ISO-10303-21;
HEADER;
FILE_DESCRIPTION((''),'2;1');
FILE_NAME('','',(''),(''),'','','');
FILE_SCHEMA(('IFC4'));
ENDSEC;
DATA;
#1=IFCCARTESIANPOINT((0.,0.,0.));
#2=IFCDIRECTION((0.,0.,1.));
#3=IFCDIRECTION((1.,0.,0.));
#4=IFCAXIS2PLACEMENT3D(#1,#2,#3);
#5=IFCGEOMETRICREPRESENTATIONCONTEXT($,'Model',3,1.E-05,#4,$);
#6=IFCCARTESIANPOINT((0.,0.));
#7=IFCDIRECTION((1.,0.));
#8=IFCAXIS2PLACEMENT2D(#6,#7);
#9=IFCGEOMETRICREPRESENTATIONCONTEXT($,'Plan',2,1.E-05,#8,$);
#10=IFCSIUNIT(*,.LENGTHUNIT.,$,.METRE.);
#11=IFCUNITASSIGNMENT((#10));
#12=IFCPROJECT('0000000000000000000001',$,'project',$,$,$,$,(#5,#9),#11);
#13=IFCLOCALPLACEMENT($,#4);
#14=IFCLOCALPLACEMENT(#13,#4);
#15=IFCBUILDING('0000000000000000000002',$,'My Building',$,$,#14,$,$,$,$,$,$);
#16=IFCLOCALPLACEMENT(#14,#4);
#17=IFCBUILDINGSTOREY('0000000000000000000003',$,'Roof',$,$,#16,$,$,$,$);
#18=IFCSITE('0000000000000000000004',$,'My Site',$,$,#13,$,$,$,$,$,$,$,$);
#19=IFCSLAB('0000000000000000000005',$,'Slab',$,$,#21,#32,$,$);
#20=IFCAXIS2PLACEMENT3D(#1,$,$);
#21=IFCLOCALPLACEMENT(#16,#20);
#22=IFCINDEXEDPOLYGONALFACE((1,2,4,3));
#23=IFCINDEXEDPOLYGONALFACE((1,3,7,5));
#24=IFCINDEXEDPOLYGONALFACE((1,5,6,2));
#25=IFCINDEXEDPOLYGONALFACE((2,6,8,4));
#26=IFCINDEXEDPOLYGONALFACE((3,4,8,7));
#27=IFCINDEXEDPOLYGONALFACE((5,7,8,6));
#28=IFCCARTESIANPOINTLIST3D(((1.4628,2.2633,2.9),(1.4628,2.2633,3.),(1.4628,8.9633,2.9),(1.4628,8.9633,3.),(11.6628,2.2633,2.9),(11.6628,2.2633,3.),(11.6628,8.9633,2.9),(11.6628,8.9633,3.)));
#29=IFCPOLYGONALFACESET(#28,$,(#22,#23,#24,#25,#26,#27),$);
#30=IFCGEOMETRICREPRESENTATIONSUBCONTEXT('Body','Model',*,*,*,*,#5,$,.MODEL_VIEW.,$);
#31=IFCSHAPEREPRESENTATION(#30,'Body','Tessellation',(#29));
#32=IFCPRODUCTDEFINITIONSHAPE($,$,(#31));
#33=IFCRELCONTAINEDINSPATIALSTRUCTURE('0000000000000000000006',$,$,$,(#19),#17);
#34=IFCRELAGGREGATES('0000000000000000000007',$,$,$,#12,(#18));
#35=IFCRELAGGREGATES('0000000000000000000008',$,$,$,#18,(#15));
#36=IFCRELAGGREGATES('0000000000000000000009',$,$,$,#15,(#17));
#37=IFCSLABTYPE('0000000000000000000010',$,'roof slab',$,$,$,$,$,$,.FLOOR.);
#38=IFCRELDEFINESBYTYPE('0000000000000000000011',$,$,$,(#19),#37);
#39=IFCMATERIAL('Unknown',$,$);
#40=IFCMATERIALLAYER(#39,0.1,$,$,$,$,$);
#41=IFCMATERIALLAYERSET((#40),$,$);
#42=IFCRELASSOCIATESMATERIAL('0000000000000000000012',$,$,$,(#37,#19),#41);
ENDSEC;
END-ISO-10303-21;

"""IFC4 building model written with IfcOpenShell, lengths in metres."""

from ifc_helpers import new_model, si_unit, frame, origin_with_axes, origin_2d_with_axis, place, context, subcontext, project, spatial, indexed_curve, outline, extrude, material, layer, layer_set, layer_usage, type_object, element, save


model = new_model("IFC4")

# Units and contexts
model_context = context("Model", 3, precision=1e-05, world=origin_with_axes())
plan_context = context("Plan", 2, precision=1e-05, world=origin_2d_with_axis())
body_context = subcontext(model_context, "Body", "Model", "MODEL_VIEW")
ifc_project = project(units=[si_unit("LENGTHUNIT", "METRE")], contexts=[model_context, plan_context])

# Site, building, storey
site_placement = place(None, origin_with_axes())
site = spatial("IfcSite", under=ifc_project, at=site_placement, Name="My Site")
building_placement = place(site_placement, origin_with_axes())
building = spatial("IfcBuilding", under=site, at=building_placement, Name="My Building")
storey_placement = place(building_placement, origin_with_axes())
storey = spatial("IfcBuildingStorey", under=building, at=storey_placement, Name="Roof")

# Slab
ifc_material = material(Name="Unknown")
ifc_layer = layer(ifc_material, 0.1)
ifc_layer_set = layer_set([ifc_layer])
ifc_layer_usage = layer_usage(ifc_layer_set, "AXIS3", "POSITIVE", -0.1)
slab_type = type_object("IfcSlabType", Name="roof slab", PredefinedType="FLOOR", material=ifc_layer_set)
slab_placement = place(storey_placement, frame((1.4628, 8.9633, 3.0), z_axis=(0.0, 0.0, 1.0), x_axis=(1.0, 0.0, 0.0)))
element("IfcSlab", 1, at=slab_placement, inside=storey, type_object=slab_type, material=ifc_layer_usage, Name="Slab", context=body_context, shape_type="SweptSolid", body=[
    extrude(outline(indexed_curve([(0.0, 0.0), (10.2, 0.0), (10.2, -6.7), (0.0, -6.7), (0.0, 0.0)])), frame((0.0, 0.0, -0.1), z_axis=(0.0, 0.0, 1.0), x_axis=(1.0, 0.0, 0.0)), (0.0, 0.0, 1.0), 0.1),
])

save(model, "model.ifc")
